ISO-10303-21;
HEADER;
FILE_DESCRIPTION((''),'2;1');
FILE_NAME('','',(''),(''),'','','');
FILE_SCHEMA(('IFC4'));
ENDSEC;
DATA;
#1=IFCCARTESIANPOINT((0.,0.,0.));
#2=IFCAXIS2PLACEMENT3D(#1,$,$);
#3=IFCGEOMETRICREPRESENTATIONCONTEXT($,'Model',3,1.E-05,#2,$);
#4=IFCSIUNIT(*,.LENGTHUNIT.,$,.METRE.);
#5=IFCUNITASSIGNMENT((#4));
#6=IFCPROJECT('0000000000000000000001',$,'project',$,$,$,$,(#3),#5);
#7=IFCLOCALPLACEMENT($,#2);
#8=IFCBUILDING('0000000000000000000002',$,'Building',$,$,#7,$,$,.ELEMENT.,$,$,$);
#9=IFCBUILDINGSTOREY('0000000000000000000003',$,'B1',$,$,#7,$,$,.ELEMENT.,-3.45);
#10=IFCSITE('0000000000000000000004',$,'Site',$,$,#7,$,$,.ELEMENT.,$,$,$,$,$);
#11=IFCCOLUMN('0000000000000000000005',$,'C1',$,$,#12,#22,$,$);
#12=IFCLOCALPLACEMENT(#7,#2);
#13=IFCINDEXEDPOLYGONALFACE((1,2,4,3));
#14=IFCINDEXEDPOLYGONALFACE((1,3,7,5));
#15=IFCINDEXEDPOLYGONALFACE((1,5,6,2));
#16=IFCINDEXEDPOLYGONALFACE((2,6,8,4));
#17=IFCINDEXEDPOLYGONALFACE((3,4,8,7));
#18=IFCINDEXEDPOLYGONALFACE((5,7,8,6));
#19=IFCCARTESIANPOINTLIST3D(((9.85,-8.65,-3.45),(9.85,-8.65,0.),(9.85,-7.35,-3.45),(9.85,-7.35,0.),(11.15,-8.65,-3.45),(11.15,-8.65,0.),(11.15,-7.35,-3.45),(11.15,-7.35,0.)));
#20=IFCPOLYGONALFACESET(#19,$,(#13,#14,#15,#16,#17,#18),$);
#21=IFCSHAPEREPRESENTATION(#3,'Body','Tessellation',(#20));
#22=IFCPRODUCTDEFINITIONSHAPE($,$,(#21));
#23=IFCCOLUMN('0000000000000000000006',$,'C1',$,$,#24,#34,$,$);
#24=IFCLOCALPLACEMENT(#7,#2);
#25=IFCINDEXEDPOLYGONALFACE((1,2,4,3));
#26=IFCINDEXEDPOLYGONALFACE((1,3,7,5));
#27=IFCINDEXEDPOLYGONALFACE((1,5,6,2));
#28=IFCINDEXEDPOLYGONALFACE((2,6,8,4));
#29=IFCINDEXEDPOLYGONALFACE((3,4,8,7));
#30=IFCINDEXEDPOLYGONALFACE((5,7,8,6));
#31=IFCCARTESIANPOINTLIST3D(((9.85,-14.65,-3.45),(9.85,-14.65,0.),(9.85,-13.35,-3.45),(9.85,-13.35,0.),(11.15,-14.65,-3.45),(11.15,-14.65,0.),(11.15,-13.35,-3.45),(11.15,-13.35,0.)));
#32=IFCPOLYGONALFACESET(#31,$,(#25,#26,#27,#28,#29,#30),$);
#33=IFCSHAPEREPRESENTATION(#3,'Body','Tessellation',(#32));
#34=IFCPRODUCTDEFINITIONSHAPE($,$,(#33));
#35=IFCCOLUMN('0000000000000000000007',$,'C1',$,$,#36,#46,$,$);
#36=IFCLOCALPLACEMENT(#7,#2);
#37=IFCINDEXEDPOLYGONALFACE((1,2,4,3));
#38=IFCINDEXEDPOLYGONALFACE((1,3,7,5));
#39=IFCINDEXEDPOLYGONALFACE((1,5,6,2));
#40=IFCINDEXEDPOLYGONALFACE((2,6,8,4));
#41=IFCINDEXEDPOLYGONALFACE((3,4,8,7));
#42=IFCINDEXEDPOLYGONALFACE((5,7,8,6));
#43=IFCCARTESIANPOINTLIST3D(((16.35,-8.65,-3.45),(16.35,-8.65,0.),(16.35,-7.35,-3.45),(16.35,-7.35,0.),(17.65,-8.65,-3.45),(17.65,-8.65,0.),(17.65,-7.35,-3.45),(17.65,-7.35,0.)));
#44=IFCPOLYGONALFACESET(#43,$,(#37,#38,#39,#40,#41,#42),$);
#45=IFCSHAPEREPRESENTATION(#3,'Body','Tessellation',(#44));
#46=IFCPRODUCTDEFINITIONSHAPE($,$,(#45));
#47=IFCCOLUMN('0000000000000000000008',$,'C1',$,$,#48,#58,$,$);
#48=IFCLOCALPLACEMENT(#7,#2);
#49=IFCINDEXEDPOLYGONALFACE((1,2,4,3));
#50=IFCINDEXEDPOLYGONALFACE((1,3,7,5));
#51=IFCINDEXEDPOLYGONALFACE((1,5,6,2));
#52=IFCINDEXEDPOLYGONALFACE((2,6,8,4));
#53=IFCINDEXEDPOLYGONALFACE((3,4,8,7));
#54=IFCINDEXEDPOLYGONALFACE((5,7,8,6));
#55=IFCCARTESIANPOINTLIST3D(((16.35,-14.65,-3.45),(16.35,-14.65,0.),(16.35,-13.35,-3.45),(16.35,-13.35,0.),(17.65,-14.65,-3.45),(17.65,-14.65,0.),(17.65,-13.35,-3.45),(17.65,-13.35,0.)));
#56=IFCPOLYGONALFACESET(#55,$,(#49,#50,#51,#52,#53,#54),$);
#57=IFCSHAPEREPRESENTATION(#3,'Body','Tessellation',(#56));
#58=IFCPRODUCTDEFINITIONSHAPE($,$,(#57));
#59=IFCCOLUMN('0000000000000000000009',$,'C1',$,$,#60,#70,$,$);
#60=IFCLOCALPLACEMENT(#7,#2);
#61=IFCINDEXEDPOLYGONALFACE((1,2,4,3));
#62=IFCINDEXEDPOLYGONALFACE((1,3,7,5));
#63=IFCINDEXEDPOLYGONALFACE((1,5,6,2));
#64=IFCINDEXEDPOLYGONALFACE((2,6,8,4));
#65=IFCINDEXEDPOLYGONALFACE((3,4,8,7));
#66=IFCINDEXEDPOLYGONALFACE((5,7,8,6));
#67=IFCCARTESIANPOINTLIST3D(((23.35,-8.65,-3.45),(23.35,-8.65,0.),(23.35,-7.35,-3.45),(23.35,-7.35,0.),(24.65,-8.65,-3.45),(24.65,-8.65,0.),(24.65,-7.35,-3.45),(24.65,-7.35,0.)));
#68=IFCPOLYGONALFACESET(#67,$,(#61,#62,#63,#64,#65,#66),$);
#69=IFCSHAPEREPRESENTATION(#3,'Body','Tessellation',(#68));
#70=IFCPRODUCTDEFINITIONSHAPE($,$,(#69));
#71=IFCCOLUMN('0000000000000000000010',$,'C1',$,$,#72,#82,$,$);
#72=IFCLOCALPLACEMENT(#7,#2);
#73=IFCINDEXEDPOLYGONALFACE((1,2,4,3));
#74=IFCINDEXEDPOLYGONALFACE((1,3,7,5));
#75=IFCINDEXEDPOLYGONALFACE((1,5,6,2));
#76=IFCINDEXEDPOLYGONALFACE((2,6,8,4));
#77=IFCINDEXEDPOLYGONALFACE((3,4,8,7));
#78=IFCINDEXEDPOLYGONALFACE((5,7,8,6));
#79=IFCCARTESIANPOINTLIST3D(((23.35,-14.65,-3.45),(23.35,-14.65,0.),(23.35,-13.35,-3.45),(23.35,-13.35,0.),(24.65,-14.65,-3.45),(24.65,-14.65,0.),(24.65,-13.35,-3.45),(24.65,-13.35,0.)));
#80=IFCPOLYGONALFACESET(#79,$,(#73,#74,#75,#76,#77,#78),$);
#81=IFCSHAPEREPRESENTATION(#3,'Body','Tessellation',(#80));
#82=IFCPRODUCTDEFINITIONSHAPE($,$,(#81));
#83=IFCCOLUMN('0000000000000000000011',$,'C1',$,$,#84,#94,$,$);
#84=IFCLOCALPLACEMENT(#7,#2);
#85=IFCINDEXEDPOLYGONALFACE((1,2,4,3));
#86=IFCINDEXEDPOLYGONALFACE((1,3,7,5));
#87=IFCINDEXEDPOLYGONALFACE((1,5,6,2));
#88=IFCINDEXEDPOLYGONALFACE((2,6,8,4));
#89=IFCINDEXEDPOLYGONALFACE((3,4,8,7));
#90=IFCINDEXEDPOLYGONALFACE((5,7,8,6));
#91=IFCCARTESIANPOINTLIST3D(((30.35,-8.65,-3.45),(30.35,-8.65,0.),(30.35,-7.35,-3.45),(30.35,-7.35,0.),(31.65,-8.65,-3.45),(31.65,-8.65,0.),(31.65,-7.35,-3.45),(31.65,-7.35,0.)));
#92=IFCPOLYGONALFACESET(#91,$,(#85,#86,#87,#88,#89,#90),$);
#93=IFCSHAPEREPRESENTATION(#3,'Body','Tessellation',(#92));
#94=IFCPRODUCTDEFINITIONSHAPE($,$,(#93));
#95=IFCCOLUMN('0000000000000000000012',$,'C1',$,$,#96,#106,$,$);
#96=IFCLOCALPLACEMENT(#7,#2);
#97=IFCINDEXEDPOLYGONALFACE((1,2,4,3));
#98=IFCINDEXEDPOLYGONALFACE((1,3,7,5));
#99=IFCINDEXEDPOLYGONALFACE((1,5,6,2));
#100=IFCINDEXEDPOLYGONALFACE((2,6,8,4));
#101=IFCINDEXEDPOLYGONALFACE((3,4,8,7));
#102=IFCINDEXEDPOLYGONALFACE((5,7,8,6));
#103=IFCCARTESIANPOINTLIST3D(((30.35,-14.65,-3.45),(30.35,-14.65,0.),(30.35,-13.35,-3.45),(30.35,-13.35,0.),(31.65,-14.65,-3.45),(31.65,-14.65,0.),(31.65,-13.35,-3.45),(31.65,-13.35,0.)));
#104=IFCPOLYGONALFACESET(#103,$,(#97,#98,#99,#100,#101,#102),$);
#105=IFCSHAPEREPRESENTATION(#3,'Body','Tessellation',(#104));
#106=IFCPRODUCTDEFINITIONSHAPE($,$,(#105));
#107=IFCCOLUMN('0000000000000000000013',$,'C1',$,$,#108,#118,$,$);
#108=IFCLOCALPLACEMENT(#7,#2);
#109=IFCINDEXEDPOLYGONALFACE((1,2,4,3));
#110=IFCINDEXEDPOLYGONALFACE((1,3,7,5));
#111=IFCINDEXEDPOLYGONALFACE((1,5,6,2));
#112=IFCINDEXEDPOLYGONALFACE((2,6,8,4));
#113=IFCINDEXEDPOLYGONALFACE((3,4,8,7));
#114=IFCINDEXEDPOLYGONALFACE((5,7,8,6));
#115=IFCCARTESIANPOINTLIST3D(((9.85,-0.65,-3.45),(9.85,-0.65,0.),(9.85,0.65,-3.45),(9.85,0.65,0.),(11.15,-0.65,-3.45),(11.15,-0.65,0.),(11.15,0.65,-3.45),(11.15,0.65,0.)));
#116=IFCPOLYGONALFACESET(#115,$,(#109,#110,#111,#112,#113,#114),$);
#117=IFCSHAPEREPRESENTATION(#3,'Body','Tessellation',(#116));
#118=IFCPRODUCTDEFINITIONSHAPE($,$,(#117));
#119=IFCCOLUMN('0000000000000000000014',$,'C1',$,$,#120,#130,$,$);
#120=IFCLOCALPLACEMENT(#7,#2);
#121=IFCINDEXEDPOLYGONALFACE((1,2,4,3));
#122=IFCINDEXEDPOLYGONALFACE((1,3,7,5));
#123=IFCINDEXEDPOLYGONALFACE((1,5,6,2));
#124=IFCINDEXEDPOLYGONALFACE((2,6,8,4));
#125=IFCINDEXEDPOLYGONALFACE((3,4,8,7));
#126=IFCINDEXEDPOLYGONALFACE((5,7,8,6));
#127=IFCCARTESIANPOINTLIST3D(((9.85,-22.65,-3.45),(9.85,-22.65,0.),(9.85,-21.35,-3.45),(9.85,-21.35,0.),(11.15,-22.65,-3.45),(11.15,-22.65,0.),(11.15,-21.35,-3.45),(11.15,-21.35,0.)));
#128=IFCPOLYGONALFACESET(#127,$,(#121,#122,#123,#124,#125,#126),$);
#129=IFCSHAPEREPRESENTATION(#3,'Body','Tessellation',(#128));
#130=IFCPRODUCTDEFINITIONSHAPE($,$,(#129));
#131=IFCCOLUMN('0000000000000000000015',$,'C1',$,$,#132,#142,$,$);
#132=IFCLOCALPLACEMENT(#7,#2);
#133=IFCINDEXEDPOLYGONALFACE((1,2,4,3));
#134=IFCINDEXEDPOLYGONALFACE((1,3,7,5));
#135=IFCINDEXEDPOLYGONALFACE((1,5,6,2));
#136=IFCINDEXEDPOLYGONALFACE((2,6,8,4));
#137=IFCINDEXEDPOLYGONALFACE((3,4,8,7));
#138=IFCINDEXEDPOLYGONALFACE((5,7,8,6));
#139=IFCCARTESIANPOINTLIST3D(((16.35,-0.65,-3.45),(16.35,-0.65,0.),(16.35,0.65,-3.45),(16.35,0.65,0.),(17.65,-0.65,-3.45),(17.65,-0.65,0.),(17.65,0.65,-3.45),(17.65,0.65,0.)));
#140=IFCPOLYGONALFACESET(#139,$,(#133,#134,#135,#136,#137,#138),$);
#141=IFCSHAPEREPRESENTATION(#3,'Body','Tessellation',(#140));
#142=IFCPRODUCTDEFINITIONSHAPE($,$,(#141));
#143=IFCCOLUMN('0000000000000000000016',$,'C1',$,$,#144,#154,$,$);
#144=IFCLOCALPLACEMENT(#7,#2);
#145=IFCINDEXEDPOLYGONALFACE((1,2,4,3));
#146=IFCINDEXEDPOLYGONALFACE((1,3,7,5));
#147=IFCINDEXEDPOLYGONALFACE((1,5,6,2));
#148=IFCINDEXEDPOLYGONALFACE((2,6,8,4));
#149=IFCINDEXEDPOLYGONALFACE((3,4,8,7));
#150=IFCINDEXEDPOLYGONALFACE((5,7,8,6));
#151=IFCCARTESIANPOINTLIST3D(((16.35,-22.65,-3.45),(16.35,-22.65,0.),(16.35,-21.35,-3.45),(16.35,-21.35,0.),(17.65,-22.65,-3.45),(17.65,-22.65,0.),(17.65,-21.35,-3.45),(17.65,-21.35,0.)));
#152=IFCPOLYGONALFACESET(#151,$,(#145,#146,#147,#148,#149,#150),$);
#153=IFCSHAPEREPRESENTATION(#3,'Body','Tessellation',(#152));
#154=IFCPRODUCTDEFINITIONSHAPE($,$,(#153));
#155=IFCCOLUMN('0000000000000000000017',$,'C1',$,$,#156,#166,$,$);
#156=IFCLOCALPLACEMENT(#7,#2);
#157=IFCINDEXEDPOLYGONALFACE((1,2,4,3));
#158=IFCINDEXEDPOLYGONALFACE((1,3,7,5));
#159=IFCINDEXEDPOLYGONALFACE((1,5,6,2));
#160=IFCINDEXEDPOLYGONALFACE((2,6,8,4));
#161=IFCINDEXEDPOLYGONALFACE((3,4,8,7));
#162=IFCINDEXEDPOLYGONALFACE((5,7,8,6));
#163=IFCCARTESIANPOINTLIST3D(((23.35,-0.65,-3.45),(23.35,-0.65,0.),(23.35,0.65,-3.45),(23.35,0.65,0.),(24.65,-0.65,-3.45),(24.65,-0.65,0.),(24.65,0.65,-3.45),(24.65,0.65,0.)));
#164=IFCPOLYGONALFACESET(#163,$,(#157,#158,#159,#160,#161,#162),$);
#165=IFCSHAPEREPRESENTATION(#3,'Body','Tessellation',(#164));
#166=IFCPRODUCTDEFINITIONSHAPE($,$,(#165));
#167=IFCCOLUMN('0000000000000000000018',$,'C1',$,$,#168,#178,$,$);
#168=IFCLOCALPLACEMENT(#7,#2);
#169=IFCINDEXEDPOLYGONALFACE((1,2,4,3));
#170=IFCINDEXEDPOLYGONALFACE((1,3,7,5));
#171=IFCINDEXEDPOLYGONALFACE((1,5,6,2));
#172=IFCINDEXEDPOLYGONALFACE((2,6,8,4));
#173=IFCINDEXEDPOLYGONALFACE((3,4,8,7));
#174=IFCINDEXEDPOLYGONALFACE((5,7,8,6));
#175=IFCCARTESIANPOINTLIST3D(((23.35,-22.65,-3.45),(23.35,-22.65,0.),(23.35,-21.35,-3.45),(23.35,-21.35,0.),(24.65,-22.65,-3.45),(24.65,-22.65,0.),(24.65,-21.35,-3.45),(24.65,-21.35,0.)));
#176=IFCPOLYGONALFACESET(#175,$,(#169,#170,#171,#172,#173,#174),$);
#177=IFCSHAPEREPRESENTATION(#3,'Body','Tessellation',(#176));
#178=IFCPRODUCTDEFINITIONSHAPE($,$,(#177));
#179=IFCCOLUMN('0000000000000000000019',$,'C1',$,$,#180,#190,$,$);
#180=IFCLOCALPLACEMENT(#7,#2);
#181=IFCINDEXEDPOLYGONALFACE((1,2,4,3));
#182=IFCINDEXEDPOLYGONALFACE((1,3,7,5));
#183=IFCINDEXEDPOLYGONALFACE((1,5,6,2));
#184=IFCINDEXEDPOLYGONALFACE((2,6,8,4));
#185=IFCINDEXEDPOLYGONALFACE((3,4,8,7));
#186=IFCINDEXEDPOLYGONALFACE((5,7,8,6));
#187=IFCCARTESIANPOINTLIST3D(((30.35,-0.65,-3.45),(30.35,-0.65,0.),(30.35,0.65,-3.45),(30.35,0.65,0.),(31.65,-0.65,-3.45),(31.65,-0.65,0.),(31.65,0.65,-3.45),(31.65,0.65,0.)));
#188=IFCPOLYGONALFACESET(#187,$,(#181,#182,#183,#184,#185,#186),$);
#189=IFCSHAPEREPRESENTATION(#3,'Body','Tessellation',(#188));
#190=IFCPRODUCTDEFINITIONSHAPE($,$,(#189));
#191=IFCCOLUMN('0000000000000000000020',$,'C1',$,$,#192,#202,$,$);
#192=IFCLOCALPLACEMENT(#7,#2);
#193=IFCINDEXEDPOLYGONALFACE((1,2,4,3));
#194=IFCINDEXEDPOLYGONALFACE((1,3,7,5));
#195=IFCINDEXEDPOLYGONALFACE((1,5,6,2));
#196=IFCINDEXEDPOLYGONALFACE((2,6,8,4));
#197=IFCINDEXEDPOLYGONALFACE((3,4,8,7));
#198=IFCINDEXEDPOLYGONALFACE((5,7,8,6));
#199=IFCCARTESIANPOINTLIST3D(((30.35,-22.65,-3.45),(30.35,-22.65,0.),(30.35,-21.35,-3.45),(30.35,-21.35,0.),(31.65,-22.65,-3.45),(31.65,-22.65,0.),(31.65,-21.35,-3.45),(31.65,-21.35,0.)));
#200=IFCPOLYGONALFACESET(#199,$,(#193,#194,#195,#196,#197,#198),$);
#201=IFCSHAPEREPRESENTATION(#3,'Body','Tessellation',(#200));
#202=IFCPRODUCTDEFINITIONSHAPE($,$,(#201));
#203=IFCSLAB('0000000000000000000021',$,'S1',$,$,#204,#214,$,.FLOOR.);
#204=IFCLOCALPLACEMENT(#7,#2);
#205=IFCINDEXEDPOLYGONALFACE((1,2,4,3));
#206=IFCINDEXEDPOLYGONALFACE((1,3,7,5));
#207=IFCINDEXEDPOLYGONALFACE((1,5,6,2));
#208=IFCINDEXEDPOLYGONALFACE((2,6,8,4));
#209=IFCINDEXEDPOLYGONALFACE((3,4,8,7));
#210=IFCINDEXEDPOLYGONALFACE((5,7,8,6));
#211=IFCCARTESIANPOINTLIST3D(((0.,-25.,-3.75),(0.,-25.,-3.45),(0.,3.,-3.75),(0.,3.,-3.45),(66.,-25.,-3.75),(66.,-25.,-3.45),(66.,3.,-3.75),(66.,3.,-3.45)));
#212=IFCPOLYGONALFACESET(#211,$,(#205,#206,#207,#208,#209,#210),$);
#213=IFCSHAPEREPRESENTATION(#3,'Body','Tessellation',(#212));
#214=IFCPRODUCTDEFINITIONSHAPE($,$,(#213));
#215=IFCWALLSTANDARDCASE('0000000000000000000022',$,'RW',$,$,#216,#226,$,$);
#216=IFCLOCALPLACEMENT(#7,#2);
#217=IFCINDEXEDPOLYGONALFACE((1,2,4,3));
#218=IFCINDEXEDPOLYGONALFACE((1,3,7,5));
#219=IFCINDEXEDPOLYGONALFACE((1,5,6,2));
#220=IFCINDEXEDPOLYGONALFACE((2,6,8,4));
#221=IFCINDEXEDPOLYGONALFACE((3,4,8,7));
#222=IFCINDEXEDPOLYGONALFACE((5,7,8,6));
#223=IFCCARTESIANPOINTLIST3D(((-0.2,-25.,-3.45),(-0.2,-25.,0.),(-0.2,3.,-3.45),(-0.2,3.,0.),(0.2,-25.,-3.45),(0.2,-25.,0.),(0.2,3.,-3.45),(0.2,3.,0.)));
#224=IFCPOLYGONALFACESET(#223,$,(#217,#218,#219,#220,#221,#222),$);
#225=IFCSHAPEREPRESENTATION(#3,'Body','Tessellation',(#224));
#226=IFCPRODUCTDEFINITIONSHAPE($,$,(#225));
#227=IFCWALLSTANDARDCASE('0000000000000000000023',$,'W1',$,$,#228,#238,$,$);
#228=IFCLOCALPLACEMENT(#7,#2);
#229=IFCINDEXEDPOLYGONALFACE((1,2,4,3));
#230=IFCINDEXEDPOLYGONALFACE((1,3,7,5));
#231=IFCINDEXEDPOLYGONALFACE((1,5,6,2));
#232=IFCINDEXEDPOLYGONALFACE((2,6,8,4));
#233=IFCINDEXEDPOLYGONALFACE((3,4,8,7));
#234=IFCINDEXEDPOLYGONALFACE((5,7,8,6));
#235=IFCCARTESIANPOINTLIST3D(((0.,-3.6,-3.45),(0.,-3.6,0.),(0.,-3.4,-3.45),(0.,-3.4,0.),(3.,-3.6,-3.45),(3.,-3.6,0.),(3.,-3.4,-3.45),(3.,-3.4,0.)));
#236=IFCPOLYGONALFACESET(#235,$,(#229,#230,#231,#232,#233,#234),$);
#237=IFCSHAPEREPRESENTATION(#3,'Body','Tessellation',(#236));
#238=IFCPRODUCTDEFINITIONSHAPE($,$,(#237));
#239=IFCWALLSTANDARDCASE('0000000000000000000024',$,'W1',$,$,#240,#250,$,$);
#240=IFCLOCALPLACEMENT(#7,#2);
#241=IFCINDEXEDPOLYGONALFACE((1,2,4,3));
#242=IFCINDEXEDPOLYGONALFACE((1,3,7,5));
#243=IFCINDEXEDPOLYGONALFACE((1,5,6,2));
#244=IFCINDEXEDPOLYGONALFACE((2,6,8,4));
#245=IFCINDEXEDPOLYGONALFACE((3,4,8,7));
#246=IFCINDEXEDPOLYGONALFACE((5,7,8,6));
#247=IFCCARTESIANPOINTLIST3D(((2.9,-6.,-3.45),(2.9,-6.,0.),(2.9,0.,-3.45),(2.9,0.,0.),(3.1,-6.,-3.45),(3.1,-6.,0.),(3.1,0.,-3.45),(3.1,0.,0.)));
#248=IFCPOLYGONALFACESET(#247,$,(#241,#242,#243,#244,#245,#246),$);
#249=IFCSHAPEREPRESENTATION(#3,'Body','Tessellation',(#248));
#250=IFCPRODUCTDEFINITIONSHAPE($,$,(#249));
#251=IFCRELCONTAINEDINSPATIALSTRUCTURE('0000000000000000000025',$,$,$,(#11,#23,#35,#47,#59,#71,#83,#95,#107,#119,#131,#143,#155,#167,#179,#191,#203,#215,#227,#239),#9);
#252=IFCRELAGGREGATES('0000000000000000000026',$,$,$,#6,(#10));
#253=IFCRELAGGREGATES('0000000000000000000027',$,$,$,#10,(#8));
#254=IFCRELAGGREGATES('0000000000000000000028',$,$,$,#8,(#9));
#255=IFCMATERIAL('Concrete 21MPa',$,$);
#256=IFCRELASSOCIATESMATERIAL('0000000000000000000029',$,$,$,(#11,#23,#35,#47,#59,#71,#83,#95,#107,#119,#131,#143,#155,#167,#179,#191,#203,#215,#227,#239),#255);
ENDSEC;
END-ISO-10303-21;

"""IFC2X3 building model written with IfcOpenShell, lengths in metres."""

from ifc_helpers import new_model, si_unit, frame, origin, origin_2d, place, context, project, spatial, rectangle, extrude, material, element, save


model = new_model("IFC2X3")

# Units and contexts
model_context = context("Model", 3, precision=1e-05, world=origin())
ifc_project = project(units=[si_unit("LENGTHUNIT", "METRE")], contexts=[model_context])

# Site, building, storey
placement = place(None, origin())
site = spatial("IfcSite", under=ifc_project, at=placement, Name="Site", CompositionType="ELEMENT")
building = spatial("IfcBuilding", under=site, at=placement, Name="Building", CompositionType="ELEMENT")
storey = spatial("IfcBuildingStorey", under=building, at=placement, Name="B1", CompositionType="ELEMENT", Elevation=-3.45)

# Columns
ifc_material = material(Name="Concrete 21MPa")
for number, where, name in (
    (1, (10.5, -8.0, -3.45), "C1"),
    (2, (10.5, -14.0, -3.45), "C1"),
    (3, (17.0, -8.0, -3.45), "C1"),
    (4, (17.0, -14.0, -3.45), "C1"),
    (5, (24.0, -8.0, -3.45), "C1"),
    (6, (24.0, -14.0, -3.45), "C1"),
    (7, (31.0, -8.0, -3.45), "C1"),
    (8, (31.0, -14.0, -3.45), "C1"),
    (9, (10.5, 0.0, -3.45), "C1"),
    (10, (10.5, -22.0, -3.45), "C1"),
    (11, (17.0, 0.0, -3.45), "C1"),
    (12, (17.0, -22.0, -3.45), "C1"),
    (13, (24.0, 0.0, -3.45), "C1"),
    (14, (24.0, -22.0, -3.45), "C1"),
    (15, (31.0, 0.0, -3.45), "C1"),
    (16, (31.0, -22.0, -3.45), "C1"),
):
    element("IfcColumn", number, at=place(None, frame(where)), inside=storey, material=ifc_material, Name=name, context=model_context, shape_type="SweptSolid", body=[
        extrude(rectangle(XDim=1.3, YDim=1.3, at=origin_2d()), origin(), (0.0, 0.0, 1.0), 3.45),
    ])

# Slab
slab_placement = place(None, frame((33.0, -11.0, -3.75)))
element("IfcSlab", 17, at=slab_placement, inside=storey, material=ifc_material, Name="S1", PredefinedType="FLOOR", context=model_context, shape_type="SweptSolid", body=[
    extrude(rectangle(XDim=66.0, YDim=28.0, at=origin_2d()), origin(), (0.0, 0.0, 1.0), 0.3),
])

# Walls
wall_1_placement = place(None, frame((0.0, -11.0, -3.45)))
element("IfcWallStandardCase", 18, at=wall_1_placement, inside=storey, material=ifc_material, Name="RW", context=model_context, shape_type="SweptSolid", body=[
    extrude(rectangle(XDim=0.4, YDim=28.0, at=origin_2d()), origin(), (0.0, 0.0, 1.0), 3.45),
])
wall_2_placement = place(None, frame((1.5, -3.5, -3.45)))
element("IfcWallStandardCase", 19, at=wall_2_placement, inside=storey, material=ifc_material, Name="W1", context=model_context, shape_type="SweptSolid", body=[
    extrude(rectangle(XDim=3.0, YDim=0.2, at=origin_2d()), origin(), (0.0, 0.0, 1.0), 3.45),
])
wall_3_placement = place(None, frame((3.0, -3.0, -3.45)))
element("IfcWallStandardCase", 20, at=wall_3_placement, inside=storey, material=ifc_material, Name="W1", context=model_context, shape_type="SweptSolid", body=[
    extrude(rectangle(XDim=0.2, YDim=6.0, at=origin_2d()), origin(), (0.0, 0.0, 1.0), 3.45),
])

save(model, "model.ifc")
